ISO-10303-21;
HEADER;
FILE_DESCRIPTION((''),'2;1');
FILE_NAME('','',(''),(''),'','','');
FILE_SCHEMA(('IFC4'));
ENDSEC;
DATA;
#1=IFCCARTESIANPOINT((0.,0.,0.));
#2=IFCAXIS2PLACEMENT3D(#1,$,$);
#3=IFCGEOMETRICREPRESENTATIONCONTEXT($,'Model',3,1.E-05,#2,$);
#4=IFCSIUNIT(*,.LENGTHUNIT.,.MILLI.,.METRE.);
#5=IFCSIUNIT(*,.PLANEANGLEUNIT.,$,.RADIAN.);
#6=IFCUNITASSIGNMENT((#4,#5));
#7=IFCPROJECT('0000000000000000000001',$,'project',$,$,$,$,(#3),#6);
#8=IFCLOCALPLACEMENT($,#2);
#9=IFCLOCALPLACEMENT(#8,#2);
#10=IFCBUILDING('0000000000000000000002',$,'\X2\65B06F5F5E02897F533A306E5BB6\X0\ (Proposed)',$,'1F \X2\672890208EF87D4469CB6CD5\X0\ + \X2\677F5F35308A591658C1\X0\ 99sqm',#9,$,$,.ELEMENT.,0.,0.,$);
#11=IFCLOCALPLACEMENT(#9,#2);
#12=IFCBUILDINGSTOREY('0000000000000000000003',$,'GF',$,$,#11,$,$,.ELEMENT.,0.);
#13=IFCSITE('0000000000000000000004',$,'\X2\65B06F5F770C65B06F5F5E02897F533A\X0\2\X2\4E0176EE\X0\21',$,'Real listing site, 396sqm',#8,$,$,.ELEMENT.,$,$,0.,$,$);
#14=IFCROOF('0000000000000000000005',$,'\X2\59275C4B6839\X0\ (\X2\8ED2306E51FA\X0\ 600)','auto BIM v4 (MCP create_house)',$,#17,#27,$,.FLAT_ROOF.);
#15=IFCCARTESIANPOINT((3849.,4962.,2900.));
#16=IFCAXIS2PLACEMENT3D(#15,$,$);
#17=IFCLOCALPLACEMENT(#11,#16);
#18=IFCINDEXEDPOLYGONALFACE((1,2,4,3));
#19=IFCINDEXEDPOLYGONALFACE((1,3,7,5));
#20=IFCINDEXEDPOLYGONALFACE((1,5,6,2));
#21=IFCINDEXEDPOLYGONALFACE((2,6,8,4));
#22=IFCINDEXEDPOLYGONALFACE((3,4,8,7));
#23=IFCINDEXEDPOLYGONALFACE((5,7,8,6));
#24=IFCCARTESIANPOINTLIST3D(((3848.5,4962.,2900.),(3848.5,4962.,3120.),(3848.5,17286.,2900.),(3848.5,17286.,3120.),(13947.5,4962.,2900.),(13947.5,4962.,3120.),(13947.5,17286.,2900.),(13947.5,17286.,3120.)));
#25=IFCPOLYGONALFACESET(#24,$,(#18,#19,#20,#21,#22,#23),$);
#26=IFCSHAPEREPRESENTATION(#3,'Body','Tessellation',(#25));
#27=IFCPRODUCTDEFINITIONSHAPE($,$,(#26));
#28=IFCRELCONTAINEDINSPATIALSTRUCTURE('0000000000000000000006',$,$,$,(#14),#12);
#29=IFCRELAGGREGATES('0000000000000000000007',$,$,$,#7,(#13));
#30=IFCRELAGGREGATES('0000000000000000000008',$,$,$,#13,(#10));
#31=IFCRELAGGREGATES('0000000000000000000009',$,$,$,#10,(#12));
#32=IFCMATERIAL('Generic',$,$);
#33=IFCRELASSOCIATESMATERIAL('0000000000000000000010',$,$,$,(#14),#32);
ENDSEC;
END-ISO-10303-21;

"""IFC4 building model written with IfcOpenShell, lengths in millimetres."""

from ifc_helpers import new_model, si_unit, frame, frame_2d, origin, place, context, project, spatial, rectangle, extrude, material, element, save


model = new_model("IFC4")

# Units and contexts
model_context = context("Model", 3, precision=1e-05, world=origin())
ifc_project = project(units=[si_unit("LENGTHUNIT", "METRE", prefix="MILLI"), si_unit("PLANEANGLEUNIT", "RADIAN")], contexts=[model_context])

# Site, building, storey
site_placement = place(None, origin())
site = spatial("IfcSite", under=ifc_project, at=site_placement, Name="新潟県新潟市西区2丁目21", ObjectType="Real listing site, 396sqm", CompositionType="ELEMENT", RefElevation=0.0)
building_placement = place(site_placement, origin())
building = spatial("IfcBuilding", under=site, at=building_placement, Name="新潟市西区の家 (Proposed)", ObjectType="1F 木造軸組構法 + 板張り外壁 99sqm", CompositionType="ELEMENT", ElevationOfRefHeight=0.0, ElevationOfTerrain=0.0)
storey_placement = place(building_placement, origin())
storey = spatial("IfcBuildingStorey", under=building, at=storey_placement, Name="GF", CompositionType="ELEMENT", Elevation=0.0)

# Shared definitions
ifc_material = material(Name="Generic")

# Roof
roof_placement = place(storey_placement, frame((3849.0, 4962.0, 2900.0)))
element("IfcRoof", 1, at=roof_placement, inside=storey, material=ifc_material, Name="大屋根 (軒の出 600)", Description="auto BIM v4 (MCP create_house)", PredefinedType="FLAT_ROOF", context=model_context, shape_type="SweptSolid", body=[
    extrude(rectangle(XDim=10099.0, YDim=12324.0, at=frame_2d((5049.0, 6162.0))), frame((3849.0, 4962.0, 2900.0)), (0.0, 0.0, 1.0), 220.0),
])

save(model, "model.ifc")
